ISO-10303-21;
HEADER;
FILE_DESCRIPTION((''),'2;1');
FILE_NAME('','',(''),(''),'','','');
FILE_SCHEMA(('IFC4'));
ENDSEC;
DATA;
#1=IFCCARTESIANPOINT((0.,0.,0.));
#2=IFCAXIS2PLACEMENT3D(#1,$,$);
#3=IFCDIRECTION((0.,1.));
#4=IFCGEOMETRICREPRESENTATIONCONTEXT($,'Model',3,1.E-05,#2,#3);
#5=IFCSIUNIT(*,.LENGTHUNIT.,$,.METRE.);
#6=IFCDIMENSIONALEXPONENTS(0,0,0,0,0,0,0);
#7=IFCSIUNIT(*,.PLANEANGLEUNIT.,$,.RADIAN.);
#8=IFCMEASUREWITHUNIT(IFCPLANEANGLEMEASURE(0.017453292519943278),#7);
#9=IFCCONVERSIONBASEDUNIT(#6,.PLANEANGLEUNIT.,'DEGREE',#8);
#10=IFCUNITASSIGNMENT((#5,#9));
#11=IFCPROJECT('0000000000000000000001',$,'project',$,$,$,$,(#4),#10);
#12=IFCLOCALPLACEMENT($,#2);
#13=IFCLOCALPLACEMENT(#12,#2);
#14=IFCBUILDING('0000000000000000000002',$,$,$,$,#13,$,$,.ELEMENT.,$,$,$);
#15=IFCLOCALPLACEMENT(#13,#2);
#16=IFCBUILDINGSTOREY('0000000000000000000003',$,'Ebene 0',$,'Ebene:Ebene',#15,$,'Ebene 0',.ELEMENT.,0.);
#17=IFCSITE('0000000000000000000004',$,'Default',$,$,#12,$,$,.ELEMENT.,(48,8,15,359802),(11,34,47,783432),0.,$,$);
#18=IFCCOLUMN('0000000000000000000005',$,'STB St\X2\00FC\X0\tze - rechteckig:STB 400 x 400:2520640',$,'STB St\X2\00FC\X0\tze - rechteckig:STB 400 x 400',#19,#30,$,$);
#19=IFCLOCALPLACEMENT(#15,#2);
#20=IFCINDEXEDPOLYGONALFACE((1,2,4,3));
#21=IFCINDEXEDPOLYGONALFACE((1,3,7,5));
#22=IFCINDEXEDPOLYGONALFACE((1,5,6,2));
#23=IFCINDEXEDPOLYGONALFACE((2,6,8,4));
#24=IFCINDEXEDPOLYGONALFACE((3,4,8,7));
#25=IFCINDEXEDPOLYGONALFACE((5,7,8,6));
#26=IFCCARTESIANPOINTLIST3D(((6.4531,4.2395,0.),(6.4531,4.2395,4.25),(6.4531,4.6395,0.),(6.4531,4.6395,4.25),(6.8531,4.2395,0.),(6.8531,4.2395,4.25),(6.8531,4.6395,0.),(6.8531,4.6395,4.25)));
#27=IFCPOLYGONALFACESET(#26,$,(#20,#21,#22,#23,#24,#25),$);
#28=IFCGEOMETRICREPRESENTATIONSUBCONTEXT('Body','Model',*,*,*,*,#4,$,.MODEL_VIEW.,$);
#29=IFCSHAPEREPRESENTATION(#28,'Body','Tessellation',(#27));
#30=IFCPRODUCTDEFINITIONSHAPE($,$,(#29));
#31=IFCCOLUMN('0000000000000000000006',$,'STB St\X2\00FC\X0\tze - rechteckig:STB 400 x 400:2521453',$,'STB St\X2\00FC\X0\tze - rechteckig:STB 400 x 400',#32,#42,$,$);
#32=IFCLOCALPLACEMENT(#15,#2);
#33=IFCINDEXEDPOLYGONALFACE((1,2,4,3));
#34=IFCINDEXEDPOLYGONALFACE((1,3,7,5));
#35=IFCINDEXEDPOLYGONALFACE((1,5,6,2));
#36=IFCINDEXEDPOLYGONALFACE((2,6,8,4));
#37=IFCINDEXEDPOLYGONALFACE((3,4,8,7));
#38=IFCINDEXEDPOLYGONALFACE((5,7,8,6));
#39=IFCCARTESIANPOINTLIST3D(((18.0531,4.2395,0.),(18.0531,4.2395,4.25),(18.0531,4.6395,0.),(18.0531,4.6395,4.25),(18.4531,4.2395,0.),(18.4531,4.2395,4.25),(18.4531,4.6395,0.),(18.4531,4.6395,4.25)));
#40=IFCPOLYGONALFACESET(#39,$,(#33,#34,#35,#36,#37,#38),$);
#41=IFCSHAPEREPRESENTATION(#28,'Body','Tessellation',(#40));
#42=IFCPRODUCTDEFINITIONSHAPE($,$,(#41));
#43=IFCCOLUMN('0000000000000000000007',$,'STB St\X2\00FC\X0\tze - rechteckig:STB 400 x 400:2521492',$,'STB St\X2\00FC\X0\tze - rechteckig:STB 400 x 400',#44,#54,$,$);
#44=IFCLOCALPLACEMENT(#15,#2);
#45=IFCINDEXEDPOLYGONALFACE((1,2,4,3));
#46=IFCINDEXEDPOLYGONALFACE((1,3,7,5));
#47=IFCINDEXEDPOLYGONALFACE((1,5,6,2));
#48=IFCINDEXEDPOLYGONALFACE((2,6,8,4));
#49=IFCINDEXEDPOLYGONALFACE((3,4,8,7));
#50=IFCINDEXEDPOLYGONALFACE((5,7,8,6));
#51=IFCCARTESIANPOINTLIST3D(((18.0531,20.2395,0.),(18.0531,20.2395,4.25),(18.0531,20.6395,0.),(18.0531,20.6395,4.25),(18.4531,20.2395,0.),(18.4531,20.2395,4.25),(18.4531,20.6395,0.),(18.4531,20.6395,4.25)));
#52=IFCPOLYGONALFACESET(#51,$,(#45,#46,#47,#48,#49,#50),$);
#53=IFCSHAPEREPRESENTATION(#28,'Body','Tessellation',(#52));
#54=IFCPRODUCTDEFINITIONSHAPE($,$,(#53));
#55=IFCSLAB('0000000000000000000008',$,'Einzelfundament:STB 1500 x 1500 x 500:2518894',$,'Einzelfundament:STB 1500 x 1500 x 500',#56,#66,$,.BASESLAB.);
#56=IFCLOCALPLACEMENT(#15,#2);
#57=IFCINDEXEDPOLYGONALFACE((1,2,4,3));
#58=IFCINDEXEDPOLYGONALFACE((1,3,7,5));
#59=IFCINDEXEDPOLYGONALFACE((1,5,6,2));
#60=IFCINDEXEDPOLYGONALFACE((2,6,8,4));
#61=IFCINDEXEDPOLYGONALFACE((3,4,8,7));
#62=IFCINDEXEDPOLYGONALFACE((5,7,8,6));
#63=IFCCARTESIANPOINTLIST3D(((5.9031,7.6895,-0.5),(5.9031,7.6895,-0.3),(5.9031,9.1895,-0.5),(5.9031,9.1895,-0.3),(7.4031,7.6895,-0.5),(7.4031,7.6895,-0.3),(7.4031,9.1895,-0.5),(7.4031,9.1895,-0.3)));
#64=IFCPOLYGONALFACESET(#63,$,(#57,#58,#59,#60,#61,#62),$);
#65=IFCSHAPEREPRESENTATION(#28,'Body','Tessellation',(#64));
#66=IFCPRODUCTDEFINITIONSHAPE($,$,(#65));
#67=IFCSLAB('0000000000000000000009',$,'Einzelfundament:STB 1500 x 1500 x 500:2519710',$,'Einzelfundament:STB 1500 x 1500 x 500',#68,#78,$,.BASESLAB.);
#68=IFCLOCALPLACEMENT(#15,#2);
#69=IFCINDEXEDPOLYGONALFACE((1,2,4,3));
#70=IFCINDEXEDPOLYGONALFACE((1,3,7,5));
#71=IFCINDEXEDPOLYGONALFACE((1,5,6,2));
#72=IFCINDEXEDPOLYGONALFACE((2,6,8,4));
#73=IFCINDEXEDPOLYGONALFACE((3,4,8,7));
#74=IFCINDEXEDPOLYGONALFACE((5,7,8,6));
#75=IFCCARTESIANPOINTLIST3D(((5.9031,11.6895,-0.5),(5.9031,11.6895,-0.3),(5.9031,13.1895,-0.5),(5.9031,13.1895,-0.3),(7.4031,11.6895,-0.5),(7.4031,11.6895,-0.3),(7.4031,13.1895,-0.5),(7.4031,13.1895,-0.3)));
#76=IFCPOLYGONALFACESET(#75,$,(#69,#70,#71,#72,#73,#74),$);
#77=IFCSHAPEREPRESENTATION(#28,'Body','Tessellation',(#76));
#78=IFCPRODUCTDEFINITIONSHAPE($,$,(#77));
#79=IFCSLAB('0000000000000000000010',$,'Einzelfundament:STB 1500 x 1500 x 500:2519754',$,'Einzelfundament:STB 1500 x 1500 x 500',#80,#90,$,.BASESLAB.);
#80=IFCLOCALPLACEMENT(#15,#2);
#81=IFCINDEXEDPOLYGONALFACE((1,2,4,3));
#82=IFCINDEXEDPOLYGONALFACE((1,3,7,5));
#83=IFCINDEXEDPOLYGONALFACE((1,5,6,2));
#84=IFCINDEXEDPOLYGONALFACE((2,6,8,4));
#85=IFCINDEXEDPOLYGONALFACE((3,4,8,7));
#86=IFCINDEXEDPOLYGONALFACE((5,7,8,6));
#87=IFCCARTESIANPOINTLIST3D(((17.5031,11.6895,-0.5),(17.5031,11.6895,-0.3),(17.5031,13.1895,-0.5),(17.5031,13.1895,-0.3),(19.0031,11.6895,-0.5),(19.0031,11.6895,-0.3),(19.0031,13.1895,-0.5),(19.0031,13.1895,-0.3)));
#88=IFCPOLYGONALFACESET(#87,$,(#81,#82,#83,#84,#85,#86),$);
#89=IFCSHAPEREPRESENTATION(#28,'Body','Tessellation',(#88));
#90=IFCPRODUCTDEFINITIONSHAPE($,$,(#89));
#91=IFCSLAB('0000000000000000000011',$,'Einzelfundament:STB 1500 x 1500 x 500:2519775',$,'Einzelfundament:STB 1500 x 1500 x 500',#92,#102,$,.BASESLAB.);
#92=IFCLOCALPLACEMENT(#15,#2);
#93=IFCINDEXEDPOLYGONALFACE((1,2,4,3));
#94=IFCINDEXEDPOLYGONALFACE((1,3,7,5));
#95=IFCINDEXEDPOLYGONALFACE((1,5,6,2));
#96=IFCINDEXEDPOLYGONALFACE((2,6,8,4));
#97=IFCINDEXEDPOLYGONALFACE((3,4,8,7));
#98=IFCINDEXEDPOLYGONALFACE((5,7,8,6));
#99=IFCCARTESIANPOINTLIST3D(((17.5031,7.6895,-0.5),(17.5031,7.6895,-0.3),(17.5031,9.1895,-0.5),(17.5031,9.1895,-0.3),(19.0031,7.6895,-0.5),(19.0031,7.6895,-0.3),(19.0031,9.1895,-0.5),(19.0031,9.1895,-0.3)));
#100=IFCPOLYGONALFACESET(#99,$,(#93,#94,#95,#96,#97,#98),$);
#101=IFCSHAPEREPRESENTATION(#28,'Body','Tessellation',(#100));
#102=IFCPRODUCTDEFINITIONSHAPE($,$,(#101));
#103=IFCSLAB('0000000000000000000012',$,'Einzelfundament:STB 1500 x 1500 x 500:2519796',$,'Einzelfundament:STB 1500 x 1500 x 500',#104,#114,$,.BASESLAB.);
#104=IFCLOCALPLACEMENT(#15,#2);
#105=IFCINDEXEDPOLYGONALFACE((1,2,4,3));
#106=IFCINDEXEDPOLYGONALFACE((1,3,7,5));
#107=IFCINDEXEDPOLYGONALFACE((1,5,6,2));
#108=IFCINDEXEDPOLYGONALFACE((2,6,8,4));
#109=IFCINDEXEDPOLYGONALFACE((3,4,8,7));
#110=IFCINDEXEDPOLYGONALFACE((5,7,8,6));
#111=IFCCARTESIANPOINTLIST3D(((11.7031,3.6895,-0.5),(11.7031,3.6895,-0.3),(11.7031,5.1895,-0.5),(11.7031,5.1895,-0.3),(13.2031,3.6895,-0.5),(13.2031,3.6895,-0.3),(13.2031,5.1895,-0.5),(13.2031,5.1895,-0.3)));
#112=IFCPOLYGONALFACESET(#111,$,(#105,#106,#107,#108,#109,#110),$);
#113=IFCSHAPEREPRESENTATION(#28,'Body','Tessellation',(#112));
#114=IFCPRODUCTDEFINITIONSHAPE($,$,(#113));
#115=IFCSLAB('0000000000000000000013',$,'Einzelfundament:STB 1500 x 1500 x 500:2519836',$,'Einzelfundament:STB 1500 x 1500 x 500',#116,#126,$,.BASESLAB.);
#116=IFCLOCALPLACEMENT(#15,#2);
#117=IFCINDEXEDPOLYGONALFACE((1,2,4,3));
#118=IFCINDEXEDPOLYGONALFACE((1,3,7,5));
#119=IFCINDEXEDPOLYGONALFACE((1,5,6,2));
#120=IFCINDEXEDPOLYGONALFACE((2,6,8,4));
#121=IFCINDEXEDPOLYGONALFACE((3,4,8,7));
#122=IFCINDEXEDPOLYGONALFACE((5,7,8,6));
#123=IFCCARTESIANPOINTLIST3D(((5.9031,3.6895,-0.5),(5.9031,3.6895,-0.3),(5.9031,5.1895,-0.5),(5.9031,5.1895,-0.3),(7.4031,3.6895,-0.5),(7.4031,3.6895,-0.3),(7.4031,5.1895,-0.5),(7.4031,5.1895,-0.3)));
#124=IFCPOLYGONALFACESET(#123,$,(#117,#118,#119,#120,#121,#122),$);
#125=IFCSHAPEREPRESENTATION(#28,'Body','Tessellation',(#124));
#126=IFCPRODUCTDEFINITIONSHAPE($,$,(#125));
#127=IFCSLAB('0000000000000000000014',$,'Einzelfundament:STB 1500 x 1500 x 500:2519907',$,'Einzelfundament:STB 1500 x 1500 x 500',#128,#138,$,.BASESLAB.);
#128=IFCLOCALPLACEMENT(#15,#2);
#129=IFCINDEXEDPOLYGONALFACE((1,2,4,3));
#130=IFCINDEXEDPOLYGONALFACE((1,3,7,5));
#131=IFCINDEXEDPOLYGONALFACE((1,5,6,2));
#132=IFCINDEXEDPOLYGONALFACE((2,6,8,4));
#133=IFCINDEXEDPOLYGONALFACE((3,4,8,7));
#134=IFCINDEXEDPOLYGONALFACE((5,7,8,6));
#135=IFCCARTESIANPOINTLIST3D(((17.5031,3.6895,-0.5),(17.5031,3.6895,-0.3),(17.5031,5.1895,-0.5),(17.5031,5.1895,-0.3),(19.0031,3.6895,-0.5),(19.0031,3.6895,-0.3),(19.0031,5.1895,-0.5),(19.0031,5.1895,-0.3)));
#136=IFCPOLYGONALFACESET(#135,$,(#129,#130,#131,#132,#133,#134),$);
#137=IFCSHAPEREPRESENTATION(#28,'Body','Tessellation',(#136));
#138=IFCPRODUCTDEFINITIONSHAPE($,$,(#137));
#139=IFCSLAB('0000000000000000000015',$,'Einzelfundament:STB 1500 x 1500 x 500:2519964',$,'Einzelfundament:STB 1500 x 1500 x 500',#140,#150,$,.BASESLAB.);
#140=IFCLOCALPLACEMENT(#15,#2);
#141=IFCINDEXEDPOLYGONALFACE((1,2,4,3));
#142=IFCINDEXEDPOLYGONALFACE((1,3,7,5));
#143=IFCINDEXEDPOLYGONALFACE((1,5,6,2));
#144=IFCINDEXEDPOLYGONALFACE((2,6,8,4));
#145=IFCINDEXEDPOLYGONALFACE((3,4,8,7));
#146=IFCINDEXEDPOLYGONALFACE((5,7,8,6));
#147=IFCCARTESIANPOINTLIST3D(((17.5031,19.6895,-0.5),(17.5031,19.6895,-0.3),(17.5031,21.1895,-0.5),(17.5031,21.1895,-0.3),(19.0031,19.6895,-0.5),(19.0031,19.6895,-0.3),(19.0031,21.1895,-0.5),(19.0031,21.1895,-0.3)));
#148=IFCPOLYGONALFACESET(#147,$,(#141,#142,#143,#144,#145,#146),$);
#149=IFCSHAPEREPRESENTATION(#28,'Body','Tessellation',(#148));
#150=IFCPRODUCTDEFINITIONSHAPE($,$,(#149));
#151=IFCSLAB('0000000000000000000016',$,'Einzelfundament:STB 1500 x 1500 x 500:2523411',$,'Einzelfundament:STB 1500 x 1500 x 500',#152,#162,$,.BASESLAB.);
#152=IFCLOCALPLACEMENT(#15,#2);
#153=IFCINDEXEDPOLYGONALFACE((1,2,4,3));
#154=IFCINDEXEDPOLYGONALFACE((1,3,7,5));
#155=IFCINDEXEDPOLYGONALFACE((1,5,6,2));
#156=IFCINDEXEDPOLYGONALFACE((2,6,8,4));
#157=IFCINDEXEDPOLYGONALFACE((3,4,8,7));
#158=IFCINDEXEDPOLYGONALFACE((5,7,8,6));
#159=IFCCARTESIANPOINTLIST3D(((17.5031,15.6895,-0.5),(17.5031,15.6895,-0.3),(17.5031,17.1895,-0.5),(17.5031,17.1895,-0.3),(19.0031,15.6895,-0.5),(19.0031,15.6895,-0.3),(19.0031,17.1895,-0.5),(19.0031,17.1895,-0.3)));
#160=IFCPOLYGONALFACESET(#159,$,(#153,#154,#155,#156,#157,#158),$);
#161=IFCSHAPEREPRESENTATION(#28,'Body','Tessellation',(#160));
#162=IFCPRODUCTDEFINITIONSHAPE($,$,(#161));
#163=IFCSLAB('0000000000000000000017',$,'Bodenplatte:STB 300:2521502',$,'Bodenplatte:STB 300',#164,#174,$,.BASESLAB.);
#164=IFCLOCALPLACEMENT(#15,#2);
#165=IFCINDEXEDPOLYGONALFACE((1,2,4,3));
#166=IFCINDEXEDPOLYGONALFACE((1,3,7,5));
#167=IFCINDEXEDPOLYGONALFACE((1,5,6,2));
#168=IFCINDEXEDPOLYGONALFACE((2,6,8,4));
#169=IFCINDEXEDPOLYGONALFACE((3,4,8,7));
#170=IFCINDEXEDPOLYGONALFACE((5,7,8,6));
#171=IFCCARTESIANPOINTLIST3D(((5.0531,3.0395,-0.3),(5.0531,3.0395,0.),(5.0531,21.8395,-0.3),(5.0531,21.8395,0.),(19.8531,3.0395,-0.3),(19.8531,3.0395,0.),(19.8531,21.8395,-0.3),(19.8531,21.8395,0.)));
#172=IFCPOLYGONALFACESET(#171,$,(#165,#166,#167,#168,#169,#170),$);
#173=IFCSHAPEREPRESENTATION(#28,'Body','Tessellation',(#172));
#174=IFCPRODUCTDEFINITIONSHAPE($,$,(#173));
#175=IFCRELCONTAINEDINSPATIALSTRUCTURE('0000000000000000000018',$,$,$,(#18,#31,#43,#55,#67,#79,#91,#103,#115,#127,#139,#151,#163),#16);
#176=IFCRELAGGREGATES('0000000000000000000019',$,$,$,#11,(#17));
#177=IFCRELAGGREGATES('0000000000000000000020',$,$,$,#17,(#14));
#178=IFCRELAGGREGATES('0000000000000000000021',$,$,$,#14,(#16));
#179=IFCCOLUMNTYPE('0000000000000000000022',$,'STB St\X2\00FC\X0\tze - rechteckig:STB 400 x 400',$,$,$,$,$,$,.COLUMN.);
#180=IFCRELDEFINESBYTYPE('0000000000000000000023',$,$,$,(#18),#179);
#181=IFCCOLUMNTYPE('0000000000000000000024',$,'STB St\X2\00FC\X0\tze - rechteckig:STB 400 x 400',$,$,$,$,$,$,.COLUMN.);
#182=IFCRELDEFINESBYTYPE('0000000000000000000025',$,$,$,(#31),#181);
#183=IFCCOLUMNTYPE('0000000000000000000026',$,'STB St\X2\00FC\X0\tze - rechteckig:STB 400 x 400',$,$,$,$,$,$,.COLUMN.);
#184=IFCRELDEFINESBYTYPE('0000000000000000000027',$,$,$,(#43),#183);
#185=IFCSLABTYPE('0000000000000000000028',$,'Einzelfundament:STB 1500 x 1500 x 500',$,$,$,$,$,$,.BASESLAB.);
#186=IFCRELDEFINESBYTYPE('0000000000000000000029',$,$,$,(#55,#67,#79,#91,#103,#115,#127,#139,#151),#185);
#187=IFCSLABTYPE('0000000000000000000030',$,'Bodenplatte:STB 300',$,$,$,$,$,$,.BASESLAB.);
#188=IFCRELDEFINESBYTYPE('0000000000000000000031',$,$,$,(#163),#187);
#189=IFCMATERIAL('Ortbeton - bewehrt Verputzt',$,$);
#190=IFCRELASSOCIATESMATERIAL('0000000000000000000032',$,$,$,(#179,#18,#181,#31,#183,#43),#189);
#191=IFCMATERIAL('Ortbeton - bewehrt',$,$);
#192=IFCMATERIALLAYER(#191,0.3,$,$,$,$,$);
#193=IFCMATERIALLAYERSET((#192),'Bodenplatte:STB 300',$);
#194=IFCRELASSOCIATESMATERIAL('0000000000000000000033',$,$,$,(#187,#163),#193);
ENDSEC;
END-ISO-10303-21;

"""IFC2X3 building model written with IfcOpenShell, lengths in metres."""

from ifc_helpers import new_model, entity, si_unit, converted_unit, direction, frame, frame_2d, origin, origin_2d_with_axis, place, context, subcontext, project, spatial, rectangle, extrude, source, transform, mapped, material, layer, layer_set, layer_usage, type_object, type_shapes, element, save


model = new_model("IFC2X3")

# Units and contexts
model_context = context("Model", 3, precision=1e-05, world=origin(), true_north=direction((0.0, 1.0)))
body_context = subcontext(model_context, "Body", "Model", "MODEL_VIEW")
ifc_project = project(units=[si_unit("LENGTHUNIT", "METRE"), converted_unit("PLANEANGLEUNIT", "DEGREE", entity("IfcPlaneAngleMeasure", 0.017453292519943278), si_unit("PLANEANGLEUNIT", "RADIAN"), dimensions=[0, 0, 0, 0, 0, 0, 0])], contexts=[model_context])

# Site, building, storey
site_placement = place(None, origin())
site = spatial("IfcSite", under=ifc_project, at=site_placement, Name="Default", CompositionType="ELEMENT", RefLatitude=(48, 8, 15, 359802), RefLongitude=(11, 34, 47, 783432), RefElevation=0.0)
building_placement = place(site_placement, origin())
building = spatial("IfcBuilding", under=site, at=building_placement, CompositionType="ELEMENT")
storey_placement = place(building_placement, origin())
storey = spatial("IfcBuildingStorey", under=building, at=storey_placement, Name="Ebene 0", ObjectType="Ebene:Ebene", LongName="Ebene 0", CompositionType="ELEMENT", Elevation=0.0)

# Columns
ifc_material_1 = material(Name="Ortbeton - bewehrt Verputzt")
column_type_1 = type_object("IfcColumnType", Name="STB Stütze - rechteckig:STB 400 x 400", PredefinedType="COLUMN", material=ifc_material_1)
shared_shape_1 = source(origin(), body_context, "Body", "SweptSolid", [
    extrude(rectangle(XDim=0.4, YDim=0.4, at=origin_2d_with_axis()), frame((6.6531, 4.4395, 0.0), z_axis=(0.0, 0.0, 1.0), x_axis=(-1.0, 0.0, 0.0)), (0.0, 0.0, 1.0), 4.25),
])
type_shapes(column_type_1, [shared_shape_1])
column_1_placement = place(storey_placement, origin())
element("IfcColumn", 1, at=column_1_placement, inside=storey, type_object=column_type_1, material=ifc_material_1, Name="STB Stütze - rechteckig:STB 400 x 400:2520640", ObjectType="STB Stütze - rechteckig:STB 400 x 400", context=body_context, shape_type="MappedRepresentation", body=[
    mapped(shared_shape_1, transform((0.0, 0.0, 0.0), scale=1.0)),
])
column_type_2 = type_object("IfcColumnType", Name="STB Stütze - rechteckig:STB 400 x 400", PredefinedType="COLUMN", material=ifc_material_1)
shared_shape_2 = source(origin(), body_context, "Body", "SweptSolid", [
    extrude(rectangle(XDim=0.4, YDim=0.4, at=origin_2d_with_axis()), frame((18.2531, 4.4395, 0.0), z_axis=(0.0, 0.0, 1.0), x_axis=(-1.0, 0.0, 0.0)), (0.0, 0.0, 1.0), 4.25),
])
type_shapes(column_type_2, [shared_shape_2])
column_2_placement = place(storey_placement, origin())
element("IfcColumn", 2, at=column_2_placement, inside=storey, type_object=column_type_2, material=ifc_material_1, Name="STB Stütze - rechteckig:STB 400 x 400:2521453", ObjectType="STB Stütze - rechteckig:STB 400 x 400", context=body_context, shape_type="MappedRepresentation", body=[
    mapped(shared_shape_2, transform((0.0, 0.0, 0.0), scale=1.0)),
])
column_type_3 = type_object("IfcColumnType", Name="STB Stütze - rechteckig:STB 400 x 400", PredefinedType="COLUMN", material=ifc_material_1)
shared_shape_3 = source(origin(), body_context, "Body", "SweptSolid", [
    extrude(rectangle(XDim=0.4, YDim=0.4, at=frame_2d((0.0, 0.0), x_axis=(1.0, 0.0))), frame((18.2531, 20.4395, 0.0), z_axis=(0.0, 0.0, 1.0), x_axis=(-1.0, 0.0, 0.0)), (0.0, 0.0, 1.0), 4.25),
])
type_shapes(column_type_3, [shared_shape_3])
column_3_placement = place(storey_placement, origin())
element("IfcColumn", 3, at=column_3_placement, inside=storey, type_object=column_type_3, material=ifc_material_1, Name="STB Stütze - rechteckig:STB 400 x 400:2521492", ObjectType="STB Stütze - rechteckig:STB 400 x 400", context=body_context, shape_type="MappedRepresentation", body=[
    mapped(shared_shape_3, transform((0.0, 0.0, 0.0), scale=1.0)),
])

# Slabs
slab_type_1 = type_object("IfcSlabType", Name="Einzelfundament:STB 1500 x 1500 x 500", PredefinedType="BASESLAB")
slab_1_placement = place(storey_placement, origin())
element("IfcSlab", 4, at=slab_1_placement, inside=storey, type_object=slab_type_1, Name="Einzelfundament:STB 1500 x 1500 x 500:2518894", ObjectType="Einzelfundament:STB 1500 x 1500 x 500", PredefinedType="BASESLAB", context=body_context, shape_type="SweptSolid", body=[
    extrude(rectangle(XDim=1.5, YDim=1.5, at=frame_2d((0.0, 0.0), x_axis=(1.0, 0.0))), frame((6.6531, 8.4395, -0.5), z_axis=(0.0, 0.0, 1.0), x_axis=(-1.0, 0.0, 0.0)), (0.0, 0.0, 1.0), 0.2),
])
slab_2_placement = place(storey_placement, origin())
element("IfcSlab", 5, at=slab_2_placement, inside=storey, type_object=slab_type_1, Name="Einzelfundament:STB 1500 x 1500 x 500:2519710", ObjectType="Einzelfundament:STB 1500 x 1500 x 500", PredefinedType="BASESLAB", context=body_context, shape_type="SweptSolid", body=[
    extrude(rectangle(XDim=1.5, YDim=1.5, at=frame_2d((0.0, 0.0), x_axis=(1.0, 0.0))), frame((6.6531, 12.4395, -0.5), z_axis=(0.0, 0.0, 1.0), x_axis=(-1.0, 0.0, 0.0)), (0.0, 0.0, 1.0), 0.2),
])
slab_3_placement = place(storey_placement, origin())
element("IfcSlab", 6, at=slab_3_placement, inside=storey, type_object=slab_type_1, Name="Einzelfundament:STB 1500 x 1500 x 500:2519754", ObjectType="Einzelfundament:STB 1500 x 1500 x 500", PredefinedType="BASESLAB", context=body_context, shape_type="SweptSolid", body=[
    extrude(rectangle(XDim=1.5, YDim=1.5, at=frame_2d((0.0, 0.0), x_axis=(1.0, 0.0))), frame((18.2531, 12.4395, -0.5), z_axis=(0.0, 0.0, 1.0), x_axis=(-1.0, 0.0, 0.0)), (0.0, 0.0, 1.0), 0.2),
])
slab_4_placement = place(storey_placement, origin())
element("IfcSlab", 7, at=slab_4_placement, inside=storey, type_object=slab_type_1, Name="Einzelfundament:STB 1500 x 1500 x 500:2519775", ObjectType="Einzelfundament:STB 1500 x 1500 x 500", PredefinedType="BASESLAB", context=body_context, shape_type="SweptSolid", body=[
    extrude(rectangle(XDim=1.5, YDim=1.5, at=frame_2d((0.0, 0.0), x_axis=(1.0, 0.0))), frame((18.2531, 8.4395, -0.5), z_axis=(0.0, 0.0, 1.0), x_axis=(-1.0, 0.0, 0.0)), (0.0, 0.0, 1.0), 0.2),
])
slab_5_placement = place(storey_placement, origin())
element("IfcSlab", 8, at=slab_5_placement, inside=storey, type_object=slab_type_1, Name="Einzelfundament:STB 1500 x 1500 x 500:2519796", ObjectType="Einzelfundament:STB 1500 x 1500 x 500", PredefinedType="BASESLAB", context=body_context, shape_type="SweptSolid", body=[
    extrude(rectangle(XDim=1.5, YDim=1.5, at=frame_2d((0.0, 0.0), x_axis=(1.0, 0.0))), frame((12.4531, 4.4395, -0.5), z_axis=(0.0, 0.0, 1.0), x_axis=(0.0, 1.0, 0.0)), (0.0, 0.0, 1.0), 0.2),
])
slab_6_placement = place(storey_placement, origin())
element("IfcSlab", 9, at=slab_6_placement, inside=storey, type_object=slab_type_1, Name="Einzelfundament:STB 1500 x 1500 x 500:2519836", ObjectType="Einzelfundament:STB 1500 x 1500 x 500", PredefinedType="BASESLAB", context=body_context, shape_type="SweptSolid", body=[
    extrude(rectangle(XDim=1.5, YDim=1.5, at=frame_2d((0.0, 0.0), x_axis=(1.0, 0.0))), frame((6.6531, 4.4395, -0.5), z_axis=(0.0, 0.0, 1.0), x_axis=(-1.0, 0.0, 0.0)), (0.0, 0.0, 1.0), 0.2),
])
slab_7_placement = place(storey_placement, origin())
element("IfcSlab", 10, at=slab_7_placement, inside=storey, type_object=slab_type_1, Name="Einzelfundament:STB 1500 x 1500 x 500:2519907", ObjectType="Einzelfundament:STB 1500 x 1500 x 500", PredefinedType="BASESLAB", context=body_context, shape_type="SweptSolid", body=[
    extrude(rectangle(XDim=1.5, YDim=1.5, at=frame_2d((0.0, 0.0), x_axis=(1.0, 0.0))), frame((18.2531, 4.4395, -0.5), z_axis=(0.0, 0.0, 1.0), x_axis=(-1.0, 0.0, 0.0)), (0.0, 0.0, 1.0), 0.2),
])
slab_8_placement = place(storey_placement, origin())
element("IfcSlab", 11, at=slab_8_placement, inside=storey, type_object=slab_type_1, Name="Einzelfundament:STB 1500 x 1500 x 500:2519964", ObjectType="Einzelfundament:STB 1500 x 1500 x 500", PredefinedType="BASESLAB", context=body_context, shape_type="SweptSolid", body=[
    extrude(rectangle(XDim=1.5, YDim=1.5, at=frame_2d((0.0, 0.0), x_axis=(1.0, 0.0))), frame((18.2531, 20.4395, -0.5), z_axis=(0.0, 0.0, 1.0), x_axis=(-1.0, 0.0, 0.0)), (0.0, 0.0, 1.0), 0.2),
])
slab_9_placement = place(storey_placement, origin())
element("IfcSlab", 12, at=slab_9_placement, inside=storey, type_object=slab_type_1, Name="Einzelfundament:STB 1500 x 1500 x 500:2523411", ObjectType="Einzelfundament:STB 1500 x 1500 x 500", PredefinedType="BASESLAB", context=body_context, shape_type="SweptSolid", body=[
    extrude(rectangle(XDim=1.5, YDim=1.5, at=frame_2d((0.0, 0.0), x_axis=(1.0, 0.0))), frame((18.2531, 16.4395, -0.5), z_axis=(0.0, 0.0, 1.0), x_axis=(-1.0, 0.0, 0.0)), (0.0, 0.0, 1.0), 0.2),
])
ifc_material_2 = material(Name="Ortbeton - bewehrt")
ifc_layer = layer(ifc_material_2, 0.3)
ifc_layer_set = layer_set([ifc_layer], Name="Bodenplatte:STB 300")
ifc_layer_usage = layer_usage(ifc_layer_set, "AXIS3", "POSITIVE", 0.0)
slab_type_2 = type_object("IfcSlabType", Name="Bodenplatte:STB 300", PredefinedType="BASESLAB", material=ifc_layer_set)
slab_10_placement = place(storey_placement, origin())
element("IfcSlab", 13, at=slab_10_placement, inside=storey, type_object=slab_type_2, material=ifc_layer_usage, Name="Bodenplatte:STB 300:2521502", ObjectType="Bodenplatte:STB 300", PredefinedType="BASESLAB", context=body_context, shape_type="SweptSolid", body=[
    extrude(rectangle(XDim=18.8, YDim=14.8, at=origin_2d_with_axis()), frame((12.4531, 12.4395, 0.0), z_axis=(0.0, 0.0, -1.0), x_axis=(0.0, 1.0, 0.0)), (0.0, 0.0, 1.0), 0.3),
])

save(model, "model.ifc")
